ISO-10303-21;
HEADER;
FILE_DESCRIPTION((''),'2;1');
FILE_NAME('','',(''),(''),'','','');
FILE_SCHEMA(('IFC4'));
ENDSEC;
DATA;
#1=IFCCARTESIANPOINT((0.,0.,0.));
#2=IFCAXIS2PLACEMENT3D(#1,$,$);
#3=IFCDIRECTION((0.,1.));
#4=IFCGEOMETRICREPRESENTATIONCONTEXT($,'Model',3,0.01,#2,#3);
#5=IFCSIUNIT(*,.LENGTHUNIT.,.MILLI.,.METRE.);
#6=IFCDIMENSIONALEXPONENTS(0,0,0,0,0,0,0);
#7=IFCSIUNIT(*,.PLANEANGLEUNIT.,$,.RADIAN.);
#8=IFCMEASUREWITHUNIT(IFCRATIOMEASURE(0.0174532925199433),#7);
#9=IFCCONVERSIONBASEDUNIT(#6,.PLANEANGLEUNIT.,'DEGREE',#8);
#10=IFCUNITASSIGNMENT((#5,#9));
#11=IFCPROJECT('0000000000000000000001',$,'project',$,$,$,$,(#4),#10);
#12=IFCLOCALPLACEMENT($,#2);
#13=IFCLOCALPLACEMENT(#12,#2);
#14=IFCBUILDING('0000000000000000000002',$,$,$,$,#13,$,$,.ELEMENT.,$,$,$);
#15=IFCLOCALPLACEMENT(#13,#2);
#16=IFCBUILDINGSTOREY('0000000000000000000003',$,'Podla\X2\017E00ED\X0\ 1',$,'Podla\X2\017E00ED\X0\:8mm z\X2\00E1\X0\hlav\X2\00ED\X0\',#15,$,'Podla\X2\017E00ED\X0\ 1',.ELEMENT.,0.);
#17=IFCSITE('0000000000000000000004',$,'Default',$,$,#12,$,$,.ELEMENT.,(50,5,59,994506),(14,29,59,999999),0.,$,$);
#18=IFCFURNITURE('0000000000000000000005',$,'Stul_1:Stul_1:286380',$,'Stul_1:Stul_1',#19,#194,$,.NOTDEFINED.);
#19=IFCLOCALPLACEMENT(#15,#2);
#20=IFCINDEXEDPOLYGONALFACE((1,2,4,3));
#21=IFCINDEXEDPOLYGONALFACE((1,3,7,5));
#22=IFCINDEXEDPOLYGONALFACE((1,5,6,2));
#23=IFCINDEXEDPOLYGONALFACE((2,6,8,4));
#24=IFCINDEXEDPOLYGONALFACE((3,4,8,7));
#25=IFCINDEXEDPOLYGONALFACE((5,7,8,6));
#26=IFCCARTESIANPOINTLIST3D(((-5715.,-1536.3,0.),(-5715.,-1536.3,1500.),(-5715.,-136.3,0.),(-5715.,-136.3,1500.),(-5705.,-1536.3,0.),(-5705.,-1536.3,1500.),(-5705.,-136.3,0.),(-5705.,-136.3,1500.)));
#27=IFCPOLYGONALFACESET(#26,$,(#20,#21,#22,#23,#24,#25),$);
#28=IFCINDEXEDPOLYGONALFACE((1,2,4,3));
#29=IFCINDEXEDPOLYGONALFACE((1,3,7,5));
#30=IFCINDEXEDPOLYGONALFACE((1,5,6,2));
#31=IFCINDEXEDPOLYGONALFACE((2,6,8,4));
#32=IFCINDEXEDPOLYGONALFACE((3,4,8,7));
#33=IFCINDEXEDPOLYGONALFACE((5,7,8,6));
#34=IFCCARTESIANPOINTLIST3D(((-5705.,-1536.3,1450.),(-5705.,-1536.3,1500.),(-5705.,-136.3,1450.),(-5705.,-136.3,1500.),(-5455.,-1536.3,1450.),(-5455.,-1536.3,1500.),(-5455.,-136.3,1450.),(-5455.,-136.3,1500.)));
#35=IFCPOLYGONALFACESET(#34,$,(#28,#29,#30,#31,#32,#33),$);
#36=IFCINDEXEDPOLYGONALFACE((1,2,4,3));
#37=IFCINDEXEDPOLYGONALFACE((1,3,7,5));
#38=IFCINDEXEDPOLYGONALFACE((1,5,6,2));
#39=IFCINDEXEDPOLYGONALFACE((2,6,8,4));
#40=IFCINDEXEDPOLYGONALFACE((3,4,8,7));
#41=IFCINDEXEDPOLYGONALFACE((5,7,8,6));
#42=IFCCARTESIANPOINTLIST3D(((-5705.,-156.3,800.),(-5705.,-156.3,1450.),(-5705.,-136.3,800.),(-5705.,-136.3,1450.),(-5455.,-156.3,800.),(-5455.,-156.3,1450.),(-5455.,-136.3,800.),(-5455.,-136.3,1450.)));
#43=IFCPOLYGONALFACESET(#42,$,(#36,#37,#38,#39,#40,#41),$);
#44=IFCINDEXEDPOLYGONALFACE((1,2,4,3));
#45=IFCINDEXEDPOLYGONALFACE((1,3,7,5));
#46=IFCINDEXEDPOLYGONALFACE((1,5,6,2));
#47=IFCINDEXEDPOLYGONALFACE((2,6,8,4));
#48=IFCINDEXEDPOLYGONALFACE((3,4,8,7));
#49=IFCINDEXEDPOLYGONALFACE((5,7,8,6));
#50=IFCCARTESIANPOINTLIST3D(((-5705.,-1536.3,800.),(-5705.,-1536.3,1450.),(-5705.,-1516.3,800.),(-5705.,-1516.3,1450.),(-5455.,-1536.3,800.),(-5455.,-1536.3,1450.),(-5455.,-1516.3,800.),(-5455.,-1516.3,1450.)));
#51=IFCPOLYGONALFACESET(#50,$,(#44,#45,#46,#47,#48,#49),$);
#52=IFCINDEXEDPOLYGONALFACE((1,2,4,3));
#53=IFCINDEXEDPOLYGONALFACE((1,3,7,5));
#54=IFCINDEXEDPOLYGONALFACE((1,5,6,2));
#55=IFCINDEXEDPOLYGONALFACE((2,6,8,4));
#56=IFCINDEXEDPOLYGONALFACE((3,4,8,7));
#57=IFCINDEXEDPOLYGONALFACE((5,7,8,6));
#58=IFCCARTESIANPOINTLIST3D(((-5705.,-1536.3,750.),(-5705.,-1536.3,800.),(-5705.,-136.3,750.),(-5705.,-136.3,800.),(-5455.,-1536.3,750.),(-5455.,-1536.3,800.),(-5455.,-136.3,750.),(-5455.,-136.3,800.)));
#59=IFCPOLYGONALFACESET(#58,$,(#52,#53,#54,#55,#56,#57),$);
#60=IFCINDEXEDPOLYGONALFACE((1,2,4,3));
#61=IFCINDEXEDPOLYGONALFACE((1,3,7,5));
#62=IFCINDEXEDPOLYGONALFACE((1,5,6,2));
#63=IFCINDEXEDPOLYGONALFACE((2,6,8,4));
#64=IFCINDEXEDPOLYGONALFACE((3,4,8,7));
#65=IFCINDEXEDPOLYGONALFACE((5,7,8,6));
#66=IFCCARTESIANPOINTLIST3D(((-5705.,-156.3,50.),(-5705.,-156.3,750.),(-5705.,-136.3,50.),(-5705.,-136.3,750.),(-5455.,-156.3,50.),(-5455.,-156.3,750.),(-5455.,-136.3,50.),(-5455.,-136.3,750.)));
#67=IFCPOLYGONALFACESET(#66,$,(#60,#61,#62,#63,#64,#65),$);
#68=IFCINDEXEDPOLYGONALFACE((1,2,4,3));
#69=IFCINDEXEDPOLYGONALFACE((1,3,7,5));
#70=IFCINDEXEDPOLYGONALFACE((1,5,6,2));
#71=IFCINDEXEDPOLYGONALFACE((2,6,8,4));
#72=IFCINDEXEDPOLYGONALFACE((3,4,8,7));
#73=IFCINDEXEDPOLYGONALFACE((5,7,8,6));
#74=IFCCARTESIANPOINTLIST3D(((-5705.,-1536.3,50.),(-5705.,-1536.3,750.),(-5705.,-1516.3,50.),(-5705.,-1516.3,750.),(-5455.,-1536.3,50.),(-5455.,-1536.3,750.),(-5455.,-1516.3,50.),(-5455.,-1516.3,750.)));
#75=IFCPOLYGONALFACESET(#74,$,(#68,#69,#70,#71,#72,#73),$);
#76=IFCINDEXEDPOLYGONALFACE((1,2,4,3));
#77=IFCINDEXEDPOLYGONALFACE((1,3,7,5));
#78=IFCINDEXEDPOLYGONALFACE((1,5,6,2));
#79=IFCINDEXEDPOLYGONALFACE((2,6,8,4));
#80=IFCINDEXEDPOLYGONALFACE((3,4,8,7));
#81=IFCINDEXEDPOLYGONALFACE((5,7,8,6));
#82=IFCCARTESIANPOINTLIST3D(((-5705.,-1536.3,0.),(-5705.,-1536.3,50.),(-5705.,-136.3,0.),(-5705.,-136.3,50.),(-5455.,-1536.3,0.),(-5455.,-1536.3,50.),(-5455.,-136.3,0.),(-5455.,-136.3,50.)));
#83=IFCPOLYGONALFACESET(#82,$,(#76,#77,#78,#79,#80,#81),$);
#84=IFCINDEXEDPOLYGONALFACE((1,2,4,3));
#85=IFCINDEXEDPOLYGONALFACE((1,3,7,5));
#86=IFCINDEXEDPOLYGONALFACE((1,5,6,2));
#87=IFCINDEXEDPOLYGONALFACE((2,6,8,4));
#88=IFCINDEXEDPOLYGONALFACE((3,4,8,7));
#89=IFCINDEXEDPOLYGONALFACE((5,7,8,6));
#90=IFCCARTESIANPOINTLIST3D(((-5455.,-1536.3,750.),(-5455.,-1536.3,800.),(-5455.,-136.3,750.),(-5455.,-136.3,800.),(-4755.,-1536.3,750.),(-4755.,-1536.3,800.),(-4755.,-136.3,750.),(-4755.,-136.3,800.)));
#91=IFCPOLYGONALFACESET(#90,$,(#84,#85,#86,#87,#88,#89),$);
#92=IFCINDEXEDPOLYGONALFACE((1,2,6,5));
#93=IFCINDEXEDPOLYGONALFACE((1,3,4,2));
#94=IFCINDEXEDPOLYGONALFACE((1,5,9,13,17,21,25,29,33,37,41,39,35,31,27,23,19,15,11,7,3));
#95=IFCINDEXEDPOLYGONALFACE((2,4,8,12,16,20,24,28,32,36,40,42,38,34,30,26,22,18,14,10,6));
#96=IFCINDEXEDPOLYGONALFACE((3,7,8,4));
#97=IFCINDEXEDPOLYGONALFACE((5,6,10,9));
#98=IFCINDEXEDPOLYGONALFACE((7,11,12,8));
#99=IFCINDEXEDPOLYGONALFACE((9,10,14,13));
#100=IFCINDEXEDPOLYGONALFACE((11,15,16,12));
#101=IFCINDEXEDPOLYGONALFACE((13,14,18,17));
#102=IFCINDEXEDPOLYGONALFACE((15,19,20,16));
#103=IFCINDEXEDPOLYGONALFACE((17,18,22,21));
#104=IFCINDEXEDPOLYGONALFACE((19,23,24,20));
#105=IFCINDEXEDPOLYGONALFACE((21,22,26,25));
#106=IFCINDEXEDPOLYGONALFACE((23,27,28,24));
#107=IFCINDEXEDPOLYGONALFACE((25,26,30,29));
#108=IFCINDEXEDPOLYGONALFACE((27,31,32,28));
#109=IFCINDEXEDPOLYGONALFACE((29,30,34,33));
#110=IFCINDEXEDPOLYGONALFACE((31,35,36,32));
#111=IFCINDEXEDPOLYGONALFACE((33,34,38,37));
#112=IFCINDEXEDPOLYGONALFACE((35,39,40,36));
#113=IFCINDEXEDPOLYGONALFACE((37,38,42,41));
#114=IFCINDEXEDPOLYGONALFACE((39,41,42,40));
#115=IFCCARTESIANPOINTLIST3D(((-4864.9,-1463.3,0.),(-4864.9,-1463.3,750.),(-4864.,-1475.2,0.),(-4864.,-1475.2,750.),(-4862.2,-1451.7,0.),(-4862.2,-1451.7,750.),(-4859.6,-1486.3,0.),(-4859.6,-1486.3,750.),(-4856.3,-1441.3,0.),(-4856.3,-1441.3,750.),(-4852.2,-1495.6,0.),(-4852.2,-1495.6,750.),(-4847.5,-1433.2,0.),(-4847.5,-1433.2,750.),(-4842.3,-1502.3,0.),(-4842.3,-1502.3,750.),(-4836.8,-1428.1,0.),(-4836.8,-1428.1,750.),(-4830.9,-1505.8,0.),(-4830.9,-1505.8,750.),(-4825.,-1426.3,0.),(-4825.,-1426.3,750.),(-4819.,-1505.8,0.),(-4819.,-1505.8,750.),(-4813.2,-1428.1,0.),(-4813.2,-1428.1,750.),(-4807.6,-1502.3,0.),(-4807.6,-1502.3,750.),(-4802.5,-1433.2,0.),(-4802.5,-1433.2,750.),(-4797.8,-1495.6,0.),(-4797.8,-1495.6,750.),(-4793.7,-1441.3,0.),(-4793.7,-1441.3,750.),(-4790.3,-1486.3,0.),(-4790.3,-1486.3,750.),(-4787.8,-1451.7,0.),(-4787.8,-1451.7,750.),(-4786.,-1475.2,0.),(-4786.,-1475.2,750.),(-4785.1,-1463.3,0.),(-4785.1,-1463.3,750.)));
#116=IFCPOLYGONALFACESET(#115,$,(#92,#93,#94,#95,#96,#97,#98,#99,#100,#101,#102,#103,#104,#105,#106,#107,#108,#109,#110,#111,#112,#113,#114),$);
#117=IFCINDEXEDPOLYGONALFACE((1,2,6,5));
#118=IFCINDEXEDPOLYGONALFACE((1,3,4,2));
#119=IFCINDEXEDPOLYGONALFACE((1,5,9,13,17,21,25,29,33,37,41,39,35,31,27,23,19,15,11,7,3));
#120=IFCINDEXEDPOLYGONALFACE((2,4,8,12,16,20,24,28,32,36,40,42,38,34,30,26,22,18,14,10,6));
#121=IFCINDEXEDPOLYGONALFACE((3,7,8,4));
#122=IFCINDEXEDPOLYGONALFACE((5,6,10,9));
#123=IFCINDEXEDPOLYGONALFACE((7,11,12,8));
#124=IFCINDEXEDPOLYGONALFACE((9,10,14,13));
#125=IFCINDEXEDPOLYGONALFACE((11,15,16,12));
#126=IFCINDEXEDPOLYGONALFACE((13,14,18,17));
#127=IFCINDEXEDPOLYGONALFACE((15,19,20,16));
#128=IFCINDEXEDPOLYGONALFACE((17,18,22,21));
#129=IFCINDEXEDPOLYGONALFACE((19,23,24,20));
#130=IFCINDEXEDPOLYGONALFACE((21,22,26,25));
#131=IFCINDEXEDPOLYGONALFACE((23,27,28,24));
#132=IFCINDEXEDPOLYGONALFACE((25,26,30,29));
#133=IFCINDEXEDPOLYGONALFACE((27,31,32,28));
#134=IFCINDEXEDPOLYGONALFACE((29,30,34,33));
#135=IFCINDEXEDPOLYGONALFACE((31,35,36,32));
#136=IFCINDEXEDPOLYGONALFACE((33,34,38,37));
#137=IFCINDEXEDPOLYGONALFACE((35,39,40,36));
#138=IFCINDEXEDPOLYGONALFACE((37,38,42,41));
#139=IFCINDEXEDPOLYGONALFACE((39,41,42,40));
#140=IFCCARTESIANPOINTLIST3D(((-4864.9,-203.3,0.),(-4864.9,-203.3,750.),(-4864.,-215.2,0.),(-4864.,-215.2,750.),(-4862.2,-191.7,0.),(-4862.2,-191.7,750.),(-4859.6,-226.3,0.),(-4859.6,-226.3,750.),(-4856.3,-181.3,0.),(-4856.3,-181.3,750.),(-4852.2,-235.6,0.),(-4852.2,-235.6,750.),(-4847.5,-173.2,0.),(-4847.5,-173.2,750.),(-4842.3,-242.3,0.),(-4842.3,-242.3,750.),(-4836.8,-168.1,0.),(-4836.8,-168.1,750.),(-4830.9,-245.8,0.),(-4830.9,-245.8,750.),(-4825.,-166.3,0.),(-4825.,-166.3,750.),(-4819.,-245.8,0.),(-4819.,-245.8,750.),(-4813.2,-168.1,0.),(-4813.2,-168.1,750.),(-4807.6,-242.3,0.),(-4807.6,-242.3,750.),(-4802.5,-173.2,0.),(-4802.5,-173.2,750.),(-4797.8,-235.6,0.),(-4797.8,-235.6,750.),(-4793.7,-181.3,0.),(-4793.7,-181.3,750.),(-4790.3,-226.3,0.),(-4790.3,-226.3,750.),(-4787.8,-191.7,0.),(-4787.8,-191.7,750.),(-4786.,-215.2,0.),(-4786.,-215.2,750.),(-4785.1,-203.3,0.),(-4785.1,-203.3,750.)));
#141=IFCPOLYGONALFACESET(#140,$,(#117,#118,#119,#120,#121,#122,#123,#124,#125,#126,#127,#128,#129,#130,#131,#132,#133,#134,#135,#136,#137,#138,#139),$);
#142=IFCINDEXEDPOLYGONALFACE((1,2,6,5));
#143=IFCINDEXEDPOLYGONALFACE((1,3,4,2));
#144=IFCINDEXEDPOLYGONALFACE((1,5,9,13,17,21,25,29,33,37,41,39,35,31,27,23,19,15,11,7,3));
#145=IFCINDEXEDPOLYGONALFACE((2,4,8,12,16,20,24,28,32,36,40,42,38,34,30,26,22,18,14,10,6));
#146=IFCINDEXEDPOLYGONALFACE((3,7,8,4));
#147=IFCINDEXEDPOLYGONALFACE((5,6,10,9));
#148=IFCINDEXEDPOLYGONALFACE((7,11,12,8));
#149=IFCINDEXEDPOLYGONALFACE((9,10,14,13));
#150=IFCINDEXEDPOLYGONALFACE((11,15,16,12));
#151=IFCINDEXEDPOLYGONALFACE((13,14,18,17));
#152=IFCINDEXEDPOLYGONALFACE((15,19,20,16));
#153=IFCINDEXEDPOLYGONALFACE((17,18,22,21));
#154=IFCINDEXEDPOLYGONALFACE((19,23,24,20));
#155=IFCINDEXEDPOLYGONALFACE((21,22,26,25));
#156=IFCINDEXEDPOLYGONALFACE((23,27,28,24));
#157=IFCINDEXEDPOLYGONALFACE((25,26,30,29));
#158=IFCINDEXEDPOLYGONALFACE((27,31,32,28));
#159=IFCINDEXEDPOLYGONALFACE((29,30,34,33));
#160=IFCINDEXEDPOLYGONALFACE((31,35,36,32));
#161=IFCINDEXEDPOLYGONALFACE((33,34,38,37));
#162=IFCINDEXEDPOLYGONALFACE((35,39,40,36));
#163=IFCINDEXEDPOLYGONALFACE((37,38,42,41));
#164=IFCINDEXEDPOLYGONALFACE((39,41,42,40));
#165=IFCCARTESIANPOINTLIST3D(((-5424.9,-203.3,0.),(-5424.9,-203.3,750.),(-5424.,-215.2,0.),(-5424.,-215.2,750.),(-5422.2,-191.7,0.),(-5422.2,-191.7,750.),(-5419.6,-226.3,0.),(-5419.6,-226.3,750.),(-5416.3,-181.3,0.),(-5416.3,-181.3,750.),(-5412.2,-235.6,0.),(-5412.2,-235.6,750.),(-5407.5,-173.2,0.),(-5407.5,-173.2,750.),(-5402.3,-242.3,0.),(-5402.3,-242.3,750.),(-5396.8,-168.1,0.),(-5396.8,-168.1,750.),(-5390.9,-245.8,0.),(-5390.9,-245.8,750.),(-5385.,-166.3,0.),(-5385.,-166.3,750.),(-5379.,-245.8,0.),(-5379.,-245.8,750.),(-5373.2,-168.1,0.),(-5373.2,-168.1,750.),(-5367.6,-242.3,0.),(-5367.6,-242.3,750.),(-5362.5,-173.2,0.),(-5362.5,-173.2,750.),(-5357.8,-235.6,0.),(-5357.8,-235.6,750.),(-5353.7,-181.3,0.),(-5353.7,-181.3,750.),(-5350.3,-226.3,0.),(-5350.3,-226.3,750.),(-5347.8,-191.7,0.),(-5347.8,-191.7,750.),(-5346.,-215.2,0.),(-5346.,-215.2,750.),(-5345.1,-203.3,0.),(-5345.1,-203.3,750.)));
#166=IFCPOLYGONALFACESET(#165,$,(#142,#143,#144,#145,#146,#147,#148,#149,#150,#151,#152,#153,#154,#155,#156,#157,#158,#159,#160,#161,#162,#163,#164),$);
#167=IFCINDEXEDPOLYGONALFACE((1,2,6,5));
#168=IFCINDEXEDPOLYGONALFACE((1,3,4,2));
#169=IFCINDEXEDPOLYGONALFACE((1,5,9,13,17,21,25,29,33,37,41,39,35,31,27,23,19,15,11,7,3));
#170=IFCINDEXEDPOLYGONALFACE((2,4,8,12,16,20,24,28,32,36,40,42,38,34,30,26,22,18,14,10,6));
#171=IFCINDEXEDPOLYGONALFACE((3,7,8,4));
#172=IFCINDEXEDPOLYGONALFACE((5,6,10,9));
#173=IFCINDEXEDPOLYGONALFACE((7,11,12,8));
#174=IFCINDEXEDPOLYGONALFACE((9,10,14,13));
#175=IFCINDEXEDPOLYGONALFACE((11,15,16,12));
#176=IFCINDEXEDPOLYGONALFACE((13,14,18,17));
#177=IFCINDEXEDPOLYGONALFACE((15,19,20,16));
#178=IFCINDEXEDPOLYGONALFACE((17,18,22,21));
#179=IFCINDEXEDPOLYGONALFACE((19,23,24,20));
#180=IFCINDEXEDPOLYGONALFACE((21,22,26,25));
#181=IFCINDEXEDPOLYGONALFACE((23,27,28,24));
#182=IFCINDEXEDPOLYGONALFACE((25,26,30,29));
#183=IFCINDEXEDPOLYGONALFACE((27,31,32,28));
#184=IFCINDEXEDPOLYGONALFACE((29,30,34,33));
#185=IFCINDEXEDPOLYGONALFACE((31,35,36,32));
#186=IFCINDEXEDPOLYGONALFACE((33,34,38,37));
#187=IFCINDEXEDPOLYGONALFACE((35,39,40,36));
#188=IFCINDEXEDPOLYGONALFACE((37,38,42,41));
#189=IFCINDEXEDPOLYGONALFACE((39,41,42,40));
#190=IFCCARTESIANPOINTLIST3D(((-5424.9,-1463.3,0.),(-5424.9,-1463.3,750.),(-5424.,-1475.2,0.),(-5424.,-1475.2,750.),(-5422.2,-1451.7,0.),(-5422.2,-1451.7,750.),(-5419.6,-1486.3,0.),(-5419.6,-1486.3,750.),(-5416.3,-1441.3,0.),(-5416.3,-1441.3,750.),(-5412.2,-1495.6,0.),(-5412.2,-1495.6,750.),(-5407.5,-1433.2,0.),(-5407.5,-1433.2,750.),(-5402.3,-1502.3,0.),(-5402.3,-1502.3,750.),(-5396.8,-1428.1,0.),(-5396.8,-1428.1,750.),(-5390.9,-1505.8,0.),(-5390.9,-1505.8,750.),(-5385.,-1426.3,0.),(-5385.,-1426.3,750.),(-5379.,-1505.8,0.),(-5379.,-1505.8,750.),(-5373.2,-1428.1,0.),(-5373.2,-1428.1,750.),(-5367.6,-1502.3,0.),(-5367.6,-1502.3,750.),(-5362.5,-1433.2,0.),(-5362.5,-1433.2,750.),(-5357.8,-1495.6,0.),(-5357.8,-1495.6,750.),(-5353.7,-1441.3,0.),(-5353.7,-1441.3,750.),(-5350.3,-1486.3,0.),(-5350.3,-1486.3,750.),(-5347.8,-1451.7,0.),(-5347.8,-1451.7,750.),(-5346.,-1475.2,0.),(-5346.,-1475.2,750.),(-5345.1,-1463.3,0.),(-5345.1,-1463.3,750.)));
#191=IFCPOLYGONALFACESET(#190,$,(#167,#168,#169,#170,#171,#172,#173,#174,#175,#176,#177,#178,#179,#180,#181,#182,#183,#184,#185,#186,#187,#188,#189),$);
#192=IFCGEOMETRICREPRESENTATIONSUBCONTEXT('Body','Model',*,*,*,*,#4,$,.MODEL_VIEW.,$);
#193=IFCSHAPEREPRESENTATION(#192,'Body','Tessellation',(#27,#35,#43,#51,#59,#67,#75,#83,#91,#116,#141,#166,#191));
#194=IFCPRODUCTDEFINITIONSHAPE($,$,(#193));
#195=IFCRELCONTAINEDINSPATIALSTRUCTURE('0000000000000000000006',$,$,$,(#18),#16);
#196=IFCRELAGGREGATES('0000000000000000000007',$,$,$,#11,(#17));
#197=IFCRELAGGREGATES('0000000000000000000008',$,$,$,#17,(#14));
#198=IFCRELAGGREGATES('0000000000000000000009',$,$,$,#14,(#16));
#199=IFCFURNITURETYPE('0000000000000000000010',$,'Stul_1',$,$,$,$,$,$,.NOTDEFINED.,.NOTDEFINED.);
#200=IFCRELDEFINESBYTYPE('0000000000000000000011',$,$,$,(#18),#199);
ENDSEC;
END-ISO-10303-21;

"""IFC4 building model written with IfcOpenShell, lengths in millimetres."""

from ifc_helpers import new_model, entity, si_unit, converted_unit, direction, frame, frame_2d, origin, origin_2d_with_axis, place, context, subcontext, project, spatial, rectangle, circle, extrude, source, transform, mapped, type_object, type_shapes, element, save


model = new_model("IFC4")

# Units and contexts
model_context = context("Model", 3, precision=0.01, world=origin(), true_north=direction((0.0, 1.0)))
body_context = subcontext(model_context, "Body", "Model", "MODEL_VIEW")
ifc_project = project(units=[si_unit("LENGTHUNIT", "METRE", prefix="MILLI"), converted_unit("PLANEANGLEUNIT", "DEGREE", entity("IfcRatioMeasure", 0.0174532925199433), si_unit("PLANEANGLEUNIT", "RADIAN"), dimensions=[0, 0, 0, 0, 0, 0, 0])], contexts=[model_context])

# Site, building, storey
site_placement = place(None, origin())
site = spatial("IfcSite", under=ifc_project, at=site_placement, Name="Default", CompositionType="ELEMENT", RefLatitude=(50, 5, 59, 994506), RefLongitude=(14, 29, 59, 999999), RefElevation=0.0)
building_placement = place(site_placement, origin())
building = spatial("IfcBuilding", under=site, at=building_placement, CompositionType="ELEMENT")
storey_placement = place(building_placement, origin())
storey = spatial("IfcBuildingStorey", under=building, at=storey_placement, Name="Podlaží 1", ObjectType="Podlaží:8mm záhlaví", LongName="Podlaží 1", CompositionType="ELEMENT", Elevation=0.0)

# Furniture
furniture_type = type_object("IfcFurnitureType", Name="Stul_1", AssemblyPlace="NOTDEFINED", PredefinedType="NOTDEFINED")
shared_shape_1 = source(origin(), body_context, "Body", "SweptSolid", [
    extrude(rectangle(XDim=1400.0, YDim=10.0, at=origin_2d_with_axis()), frame((0.0, 605.0, 0.0), z_axis=(0.0, 0.0, 1.0), x_axis=(-1.0, 0.0, 0.0)), (0.0, 0.0, 1.0), 1500.0),
    extrude(rectangle(XDim=1400.0, YDim=250.0, at=frame_2d((0.0, 0.0), x_axis=(1.0, 0.0))), frame((0.0, 475.0, 1450.0), z_axis=(0.0, 0.0, 1.0), x_axis=(-1.0, 0.0, 0.0)), (0.0, 0.0, 1.0), 50.0),
    extrude(rectangle(XDim=20.0, YDim=250.0, at=origin_2d_with_axis()), frame((690.0, 475.0, 800.0), z_axis=(0.0, 0.0, 1.0), x_axis=(-1.0, 0.0, 0.0)), (0.0, 0.0, 1.0), 650.0),
    extrude(rectangle(XDim=20.0, YDim=250.0, at=frame_2d((0.0, 0.0), x_axis=(1.0, 0.0))), frame((-690.0, 475.0, 800.0), z_axis=(0.0, 0.0, 1.0), x_axis=(-1.0, 0.0, 0.0)), (0.0, 0.0, 1.0), 650.0),
    extrude(rectangle(XDim=1400.0, YDim=250.0, at=origin_2d_with_axis()), frame((0.0, 475.0, 750.0), z_axis=(0.0, 0.0, 1.0), x_axis=(-1.0, 0.0, 0.0)), (0.0, 0.0, 1.0), 50.0),
    extrude(rectangle(XDim=20.0, YDim=250.0, at=origin_2d_with_axis()), frame((690.0, 475.0, 50.0), z_axis=(0.0, 0.0, 1.0), x_axis=(-1.0, 0.0, 0.0)), (0.0, 0.0, 1.0), 700.0),
    extrude(rectangle(XDim=20.0, YDim=250.0, at=frame_2d((0.0, 0.0), x_axis=(1.0, 0.0))), frame((-690.0, 475.0, 50.0), z_axis=(0.0, 0.0, 1.0), x_axis=(-1.0, 0.0, 0.0)), (0.0, 0.0, 1.0), 700.0),
    extrude(rectangle(XDim=1400.0, YDim=250.0, at=origin_2d_with_axis()), frame((0.0, 475.0, 0.0), z_axis=(0.0, 0.0, 1.0), x_axis=(-1.0, 0.0, 0.0)), (0.0, 0.0, 1.0), 50.0),
    extrude(rectangle(XDim=1400.0, YDim=700.0, at=origin_2d_with_axis()), frame((0.0, 0.0, 750.0), z_axis=(0.0, 0.0, 1.0), x_axis=(-1.0, 0.0, 0.0)), (0.0, 0.0, 1.0), 50.0),
    extrude(circle(Radius=40.0, at=frame_2d((0.0, 0.0), x_axis=(1.0, 0.0))), frame((-630.0, -280.0, 0.0)), (0.0, 0.0, 1.0), 750.0),
    extrude(circle(Radius=40.0, at=frame_2d((0.0, 0.0), x_axis=(1.0, 0.0))), frame((630.0, -280.0, 0.0)), (0.0, 0.0, 1.0), 750.0),
    extrude(circle(Radius=40.0, at=frame_2d((0.0, 0.0), x_axis=(1.0, 0.0))), frame((630.0, 280.0, 0.0)), (0.0, 0.0, 1.0), 750.0),
    extrude(circle(Radius=40.0, at=frame_2d((0.0, 0.0), x_axis=(1.0, 0.0))), frame((-630.0, 280.0, 0.0)), (0.0, 0.0, 1.0), 750.0),
])
type_shapes(furniture_type, [shared_shape_1])
for number, where, z_axis, x_axis, name in (
    (1, (-5105.0, -836.3, 0.0), (0.0, 0.0, 1.0), (0.0, 1.0, 0.0), "Stul_1:Stul_1:286380"),
):
    element("IfcFurniture", number, at=place(storey_placement, frame(where, z_axis=z_axis, x_axis=x_axis)), inside=storey, type_object=furniture_type, Name=name, ObjectType="Stul_1:Stul_1", PredefinedType="NOTDEFINED", context=body_context, shape_type="MappedRepresentation", body=[
        mapped(shared_shape_1, transform((0.0, 0.0, 0.0), scale=1.0)),
    ])

save(model, "model.ifc")
